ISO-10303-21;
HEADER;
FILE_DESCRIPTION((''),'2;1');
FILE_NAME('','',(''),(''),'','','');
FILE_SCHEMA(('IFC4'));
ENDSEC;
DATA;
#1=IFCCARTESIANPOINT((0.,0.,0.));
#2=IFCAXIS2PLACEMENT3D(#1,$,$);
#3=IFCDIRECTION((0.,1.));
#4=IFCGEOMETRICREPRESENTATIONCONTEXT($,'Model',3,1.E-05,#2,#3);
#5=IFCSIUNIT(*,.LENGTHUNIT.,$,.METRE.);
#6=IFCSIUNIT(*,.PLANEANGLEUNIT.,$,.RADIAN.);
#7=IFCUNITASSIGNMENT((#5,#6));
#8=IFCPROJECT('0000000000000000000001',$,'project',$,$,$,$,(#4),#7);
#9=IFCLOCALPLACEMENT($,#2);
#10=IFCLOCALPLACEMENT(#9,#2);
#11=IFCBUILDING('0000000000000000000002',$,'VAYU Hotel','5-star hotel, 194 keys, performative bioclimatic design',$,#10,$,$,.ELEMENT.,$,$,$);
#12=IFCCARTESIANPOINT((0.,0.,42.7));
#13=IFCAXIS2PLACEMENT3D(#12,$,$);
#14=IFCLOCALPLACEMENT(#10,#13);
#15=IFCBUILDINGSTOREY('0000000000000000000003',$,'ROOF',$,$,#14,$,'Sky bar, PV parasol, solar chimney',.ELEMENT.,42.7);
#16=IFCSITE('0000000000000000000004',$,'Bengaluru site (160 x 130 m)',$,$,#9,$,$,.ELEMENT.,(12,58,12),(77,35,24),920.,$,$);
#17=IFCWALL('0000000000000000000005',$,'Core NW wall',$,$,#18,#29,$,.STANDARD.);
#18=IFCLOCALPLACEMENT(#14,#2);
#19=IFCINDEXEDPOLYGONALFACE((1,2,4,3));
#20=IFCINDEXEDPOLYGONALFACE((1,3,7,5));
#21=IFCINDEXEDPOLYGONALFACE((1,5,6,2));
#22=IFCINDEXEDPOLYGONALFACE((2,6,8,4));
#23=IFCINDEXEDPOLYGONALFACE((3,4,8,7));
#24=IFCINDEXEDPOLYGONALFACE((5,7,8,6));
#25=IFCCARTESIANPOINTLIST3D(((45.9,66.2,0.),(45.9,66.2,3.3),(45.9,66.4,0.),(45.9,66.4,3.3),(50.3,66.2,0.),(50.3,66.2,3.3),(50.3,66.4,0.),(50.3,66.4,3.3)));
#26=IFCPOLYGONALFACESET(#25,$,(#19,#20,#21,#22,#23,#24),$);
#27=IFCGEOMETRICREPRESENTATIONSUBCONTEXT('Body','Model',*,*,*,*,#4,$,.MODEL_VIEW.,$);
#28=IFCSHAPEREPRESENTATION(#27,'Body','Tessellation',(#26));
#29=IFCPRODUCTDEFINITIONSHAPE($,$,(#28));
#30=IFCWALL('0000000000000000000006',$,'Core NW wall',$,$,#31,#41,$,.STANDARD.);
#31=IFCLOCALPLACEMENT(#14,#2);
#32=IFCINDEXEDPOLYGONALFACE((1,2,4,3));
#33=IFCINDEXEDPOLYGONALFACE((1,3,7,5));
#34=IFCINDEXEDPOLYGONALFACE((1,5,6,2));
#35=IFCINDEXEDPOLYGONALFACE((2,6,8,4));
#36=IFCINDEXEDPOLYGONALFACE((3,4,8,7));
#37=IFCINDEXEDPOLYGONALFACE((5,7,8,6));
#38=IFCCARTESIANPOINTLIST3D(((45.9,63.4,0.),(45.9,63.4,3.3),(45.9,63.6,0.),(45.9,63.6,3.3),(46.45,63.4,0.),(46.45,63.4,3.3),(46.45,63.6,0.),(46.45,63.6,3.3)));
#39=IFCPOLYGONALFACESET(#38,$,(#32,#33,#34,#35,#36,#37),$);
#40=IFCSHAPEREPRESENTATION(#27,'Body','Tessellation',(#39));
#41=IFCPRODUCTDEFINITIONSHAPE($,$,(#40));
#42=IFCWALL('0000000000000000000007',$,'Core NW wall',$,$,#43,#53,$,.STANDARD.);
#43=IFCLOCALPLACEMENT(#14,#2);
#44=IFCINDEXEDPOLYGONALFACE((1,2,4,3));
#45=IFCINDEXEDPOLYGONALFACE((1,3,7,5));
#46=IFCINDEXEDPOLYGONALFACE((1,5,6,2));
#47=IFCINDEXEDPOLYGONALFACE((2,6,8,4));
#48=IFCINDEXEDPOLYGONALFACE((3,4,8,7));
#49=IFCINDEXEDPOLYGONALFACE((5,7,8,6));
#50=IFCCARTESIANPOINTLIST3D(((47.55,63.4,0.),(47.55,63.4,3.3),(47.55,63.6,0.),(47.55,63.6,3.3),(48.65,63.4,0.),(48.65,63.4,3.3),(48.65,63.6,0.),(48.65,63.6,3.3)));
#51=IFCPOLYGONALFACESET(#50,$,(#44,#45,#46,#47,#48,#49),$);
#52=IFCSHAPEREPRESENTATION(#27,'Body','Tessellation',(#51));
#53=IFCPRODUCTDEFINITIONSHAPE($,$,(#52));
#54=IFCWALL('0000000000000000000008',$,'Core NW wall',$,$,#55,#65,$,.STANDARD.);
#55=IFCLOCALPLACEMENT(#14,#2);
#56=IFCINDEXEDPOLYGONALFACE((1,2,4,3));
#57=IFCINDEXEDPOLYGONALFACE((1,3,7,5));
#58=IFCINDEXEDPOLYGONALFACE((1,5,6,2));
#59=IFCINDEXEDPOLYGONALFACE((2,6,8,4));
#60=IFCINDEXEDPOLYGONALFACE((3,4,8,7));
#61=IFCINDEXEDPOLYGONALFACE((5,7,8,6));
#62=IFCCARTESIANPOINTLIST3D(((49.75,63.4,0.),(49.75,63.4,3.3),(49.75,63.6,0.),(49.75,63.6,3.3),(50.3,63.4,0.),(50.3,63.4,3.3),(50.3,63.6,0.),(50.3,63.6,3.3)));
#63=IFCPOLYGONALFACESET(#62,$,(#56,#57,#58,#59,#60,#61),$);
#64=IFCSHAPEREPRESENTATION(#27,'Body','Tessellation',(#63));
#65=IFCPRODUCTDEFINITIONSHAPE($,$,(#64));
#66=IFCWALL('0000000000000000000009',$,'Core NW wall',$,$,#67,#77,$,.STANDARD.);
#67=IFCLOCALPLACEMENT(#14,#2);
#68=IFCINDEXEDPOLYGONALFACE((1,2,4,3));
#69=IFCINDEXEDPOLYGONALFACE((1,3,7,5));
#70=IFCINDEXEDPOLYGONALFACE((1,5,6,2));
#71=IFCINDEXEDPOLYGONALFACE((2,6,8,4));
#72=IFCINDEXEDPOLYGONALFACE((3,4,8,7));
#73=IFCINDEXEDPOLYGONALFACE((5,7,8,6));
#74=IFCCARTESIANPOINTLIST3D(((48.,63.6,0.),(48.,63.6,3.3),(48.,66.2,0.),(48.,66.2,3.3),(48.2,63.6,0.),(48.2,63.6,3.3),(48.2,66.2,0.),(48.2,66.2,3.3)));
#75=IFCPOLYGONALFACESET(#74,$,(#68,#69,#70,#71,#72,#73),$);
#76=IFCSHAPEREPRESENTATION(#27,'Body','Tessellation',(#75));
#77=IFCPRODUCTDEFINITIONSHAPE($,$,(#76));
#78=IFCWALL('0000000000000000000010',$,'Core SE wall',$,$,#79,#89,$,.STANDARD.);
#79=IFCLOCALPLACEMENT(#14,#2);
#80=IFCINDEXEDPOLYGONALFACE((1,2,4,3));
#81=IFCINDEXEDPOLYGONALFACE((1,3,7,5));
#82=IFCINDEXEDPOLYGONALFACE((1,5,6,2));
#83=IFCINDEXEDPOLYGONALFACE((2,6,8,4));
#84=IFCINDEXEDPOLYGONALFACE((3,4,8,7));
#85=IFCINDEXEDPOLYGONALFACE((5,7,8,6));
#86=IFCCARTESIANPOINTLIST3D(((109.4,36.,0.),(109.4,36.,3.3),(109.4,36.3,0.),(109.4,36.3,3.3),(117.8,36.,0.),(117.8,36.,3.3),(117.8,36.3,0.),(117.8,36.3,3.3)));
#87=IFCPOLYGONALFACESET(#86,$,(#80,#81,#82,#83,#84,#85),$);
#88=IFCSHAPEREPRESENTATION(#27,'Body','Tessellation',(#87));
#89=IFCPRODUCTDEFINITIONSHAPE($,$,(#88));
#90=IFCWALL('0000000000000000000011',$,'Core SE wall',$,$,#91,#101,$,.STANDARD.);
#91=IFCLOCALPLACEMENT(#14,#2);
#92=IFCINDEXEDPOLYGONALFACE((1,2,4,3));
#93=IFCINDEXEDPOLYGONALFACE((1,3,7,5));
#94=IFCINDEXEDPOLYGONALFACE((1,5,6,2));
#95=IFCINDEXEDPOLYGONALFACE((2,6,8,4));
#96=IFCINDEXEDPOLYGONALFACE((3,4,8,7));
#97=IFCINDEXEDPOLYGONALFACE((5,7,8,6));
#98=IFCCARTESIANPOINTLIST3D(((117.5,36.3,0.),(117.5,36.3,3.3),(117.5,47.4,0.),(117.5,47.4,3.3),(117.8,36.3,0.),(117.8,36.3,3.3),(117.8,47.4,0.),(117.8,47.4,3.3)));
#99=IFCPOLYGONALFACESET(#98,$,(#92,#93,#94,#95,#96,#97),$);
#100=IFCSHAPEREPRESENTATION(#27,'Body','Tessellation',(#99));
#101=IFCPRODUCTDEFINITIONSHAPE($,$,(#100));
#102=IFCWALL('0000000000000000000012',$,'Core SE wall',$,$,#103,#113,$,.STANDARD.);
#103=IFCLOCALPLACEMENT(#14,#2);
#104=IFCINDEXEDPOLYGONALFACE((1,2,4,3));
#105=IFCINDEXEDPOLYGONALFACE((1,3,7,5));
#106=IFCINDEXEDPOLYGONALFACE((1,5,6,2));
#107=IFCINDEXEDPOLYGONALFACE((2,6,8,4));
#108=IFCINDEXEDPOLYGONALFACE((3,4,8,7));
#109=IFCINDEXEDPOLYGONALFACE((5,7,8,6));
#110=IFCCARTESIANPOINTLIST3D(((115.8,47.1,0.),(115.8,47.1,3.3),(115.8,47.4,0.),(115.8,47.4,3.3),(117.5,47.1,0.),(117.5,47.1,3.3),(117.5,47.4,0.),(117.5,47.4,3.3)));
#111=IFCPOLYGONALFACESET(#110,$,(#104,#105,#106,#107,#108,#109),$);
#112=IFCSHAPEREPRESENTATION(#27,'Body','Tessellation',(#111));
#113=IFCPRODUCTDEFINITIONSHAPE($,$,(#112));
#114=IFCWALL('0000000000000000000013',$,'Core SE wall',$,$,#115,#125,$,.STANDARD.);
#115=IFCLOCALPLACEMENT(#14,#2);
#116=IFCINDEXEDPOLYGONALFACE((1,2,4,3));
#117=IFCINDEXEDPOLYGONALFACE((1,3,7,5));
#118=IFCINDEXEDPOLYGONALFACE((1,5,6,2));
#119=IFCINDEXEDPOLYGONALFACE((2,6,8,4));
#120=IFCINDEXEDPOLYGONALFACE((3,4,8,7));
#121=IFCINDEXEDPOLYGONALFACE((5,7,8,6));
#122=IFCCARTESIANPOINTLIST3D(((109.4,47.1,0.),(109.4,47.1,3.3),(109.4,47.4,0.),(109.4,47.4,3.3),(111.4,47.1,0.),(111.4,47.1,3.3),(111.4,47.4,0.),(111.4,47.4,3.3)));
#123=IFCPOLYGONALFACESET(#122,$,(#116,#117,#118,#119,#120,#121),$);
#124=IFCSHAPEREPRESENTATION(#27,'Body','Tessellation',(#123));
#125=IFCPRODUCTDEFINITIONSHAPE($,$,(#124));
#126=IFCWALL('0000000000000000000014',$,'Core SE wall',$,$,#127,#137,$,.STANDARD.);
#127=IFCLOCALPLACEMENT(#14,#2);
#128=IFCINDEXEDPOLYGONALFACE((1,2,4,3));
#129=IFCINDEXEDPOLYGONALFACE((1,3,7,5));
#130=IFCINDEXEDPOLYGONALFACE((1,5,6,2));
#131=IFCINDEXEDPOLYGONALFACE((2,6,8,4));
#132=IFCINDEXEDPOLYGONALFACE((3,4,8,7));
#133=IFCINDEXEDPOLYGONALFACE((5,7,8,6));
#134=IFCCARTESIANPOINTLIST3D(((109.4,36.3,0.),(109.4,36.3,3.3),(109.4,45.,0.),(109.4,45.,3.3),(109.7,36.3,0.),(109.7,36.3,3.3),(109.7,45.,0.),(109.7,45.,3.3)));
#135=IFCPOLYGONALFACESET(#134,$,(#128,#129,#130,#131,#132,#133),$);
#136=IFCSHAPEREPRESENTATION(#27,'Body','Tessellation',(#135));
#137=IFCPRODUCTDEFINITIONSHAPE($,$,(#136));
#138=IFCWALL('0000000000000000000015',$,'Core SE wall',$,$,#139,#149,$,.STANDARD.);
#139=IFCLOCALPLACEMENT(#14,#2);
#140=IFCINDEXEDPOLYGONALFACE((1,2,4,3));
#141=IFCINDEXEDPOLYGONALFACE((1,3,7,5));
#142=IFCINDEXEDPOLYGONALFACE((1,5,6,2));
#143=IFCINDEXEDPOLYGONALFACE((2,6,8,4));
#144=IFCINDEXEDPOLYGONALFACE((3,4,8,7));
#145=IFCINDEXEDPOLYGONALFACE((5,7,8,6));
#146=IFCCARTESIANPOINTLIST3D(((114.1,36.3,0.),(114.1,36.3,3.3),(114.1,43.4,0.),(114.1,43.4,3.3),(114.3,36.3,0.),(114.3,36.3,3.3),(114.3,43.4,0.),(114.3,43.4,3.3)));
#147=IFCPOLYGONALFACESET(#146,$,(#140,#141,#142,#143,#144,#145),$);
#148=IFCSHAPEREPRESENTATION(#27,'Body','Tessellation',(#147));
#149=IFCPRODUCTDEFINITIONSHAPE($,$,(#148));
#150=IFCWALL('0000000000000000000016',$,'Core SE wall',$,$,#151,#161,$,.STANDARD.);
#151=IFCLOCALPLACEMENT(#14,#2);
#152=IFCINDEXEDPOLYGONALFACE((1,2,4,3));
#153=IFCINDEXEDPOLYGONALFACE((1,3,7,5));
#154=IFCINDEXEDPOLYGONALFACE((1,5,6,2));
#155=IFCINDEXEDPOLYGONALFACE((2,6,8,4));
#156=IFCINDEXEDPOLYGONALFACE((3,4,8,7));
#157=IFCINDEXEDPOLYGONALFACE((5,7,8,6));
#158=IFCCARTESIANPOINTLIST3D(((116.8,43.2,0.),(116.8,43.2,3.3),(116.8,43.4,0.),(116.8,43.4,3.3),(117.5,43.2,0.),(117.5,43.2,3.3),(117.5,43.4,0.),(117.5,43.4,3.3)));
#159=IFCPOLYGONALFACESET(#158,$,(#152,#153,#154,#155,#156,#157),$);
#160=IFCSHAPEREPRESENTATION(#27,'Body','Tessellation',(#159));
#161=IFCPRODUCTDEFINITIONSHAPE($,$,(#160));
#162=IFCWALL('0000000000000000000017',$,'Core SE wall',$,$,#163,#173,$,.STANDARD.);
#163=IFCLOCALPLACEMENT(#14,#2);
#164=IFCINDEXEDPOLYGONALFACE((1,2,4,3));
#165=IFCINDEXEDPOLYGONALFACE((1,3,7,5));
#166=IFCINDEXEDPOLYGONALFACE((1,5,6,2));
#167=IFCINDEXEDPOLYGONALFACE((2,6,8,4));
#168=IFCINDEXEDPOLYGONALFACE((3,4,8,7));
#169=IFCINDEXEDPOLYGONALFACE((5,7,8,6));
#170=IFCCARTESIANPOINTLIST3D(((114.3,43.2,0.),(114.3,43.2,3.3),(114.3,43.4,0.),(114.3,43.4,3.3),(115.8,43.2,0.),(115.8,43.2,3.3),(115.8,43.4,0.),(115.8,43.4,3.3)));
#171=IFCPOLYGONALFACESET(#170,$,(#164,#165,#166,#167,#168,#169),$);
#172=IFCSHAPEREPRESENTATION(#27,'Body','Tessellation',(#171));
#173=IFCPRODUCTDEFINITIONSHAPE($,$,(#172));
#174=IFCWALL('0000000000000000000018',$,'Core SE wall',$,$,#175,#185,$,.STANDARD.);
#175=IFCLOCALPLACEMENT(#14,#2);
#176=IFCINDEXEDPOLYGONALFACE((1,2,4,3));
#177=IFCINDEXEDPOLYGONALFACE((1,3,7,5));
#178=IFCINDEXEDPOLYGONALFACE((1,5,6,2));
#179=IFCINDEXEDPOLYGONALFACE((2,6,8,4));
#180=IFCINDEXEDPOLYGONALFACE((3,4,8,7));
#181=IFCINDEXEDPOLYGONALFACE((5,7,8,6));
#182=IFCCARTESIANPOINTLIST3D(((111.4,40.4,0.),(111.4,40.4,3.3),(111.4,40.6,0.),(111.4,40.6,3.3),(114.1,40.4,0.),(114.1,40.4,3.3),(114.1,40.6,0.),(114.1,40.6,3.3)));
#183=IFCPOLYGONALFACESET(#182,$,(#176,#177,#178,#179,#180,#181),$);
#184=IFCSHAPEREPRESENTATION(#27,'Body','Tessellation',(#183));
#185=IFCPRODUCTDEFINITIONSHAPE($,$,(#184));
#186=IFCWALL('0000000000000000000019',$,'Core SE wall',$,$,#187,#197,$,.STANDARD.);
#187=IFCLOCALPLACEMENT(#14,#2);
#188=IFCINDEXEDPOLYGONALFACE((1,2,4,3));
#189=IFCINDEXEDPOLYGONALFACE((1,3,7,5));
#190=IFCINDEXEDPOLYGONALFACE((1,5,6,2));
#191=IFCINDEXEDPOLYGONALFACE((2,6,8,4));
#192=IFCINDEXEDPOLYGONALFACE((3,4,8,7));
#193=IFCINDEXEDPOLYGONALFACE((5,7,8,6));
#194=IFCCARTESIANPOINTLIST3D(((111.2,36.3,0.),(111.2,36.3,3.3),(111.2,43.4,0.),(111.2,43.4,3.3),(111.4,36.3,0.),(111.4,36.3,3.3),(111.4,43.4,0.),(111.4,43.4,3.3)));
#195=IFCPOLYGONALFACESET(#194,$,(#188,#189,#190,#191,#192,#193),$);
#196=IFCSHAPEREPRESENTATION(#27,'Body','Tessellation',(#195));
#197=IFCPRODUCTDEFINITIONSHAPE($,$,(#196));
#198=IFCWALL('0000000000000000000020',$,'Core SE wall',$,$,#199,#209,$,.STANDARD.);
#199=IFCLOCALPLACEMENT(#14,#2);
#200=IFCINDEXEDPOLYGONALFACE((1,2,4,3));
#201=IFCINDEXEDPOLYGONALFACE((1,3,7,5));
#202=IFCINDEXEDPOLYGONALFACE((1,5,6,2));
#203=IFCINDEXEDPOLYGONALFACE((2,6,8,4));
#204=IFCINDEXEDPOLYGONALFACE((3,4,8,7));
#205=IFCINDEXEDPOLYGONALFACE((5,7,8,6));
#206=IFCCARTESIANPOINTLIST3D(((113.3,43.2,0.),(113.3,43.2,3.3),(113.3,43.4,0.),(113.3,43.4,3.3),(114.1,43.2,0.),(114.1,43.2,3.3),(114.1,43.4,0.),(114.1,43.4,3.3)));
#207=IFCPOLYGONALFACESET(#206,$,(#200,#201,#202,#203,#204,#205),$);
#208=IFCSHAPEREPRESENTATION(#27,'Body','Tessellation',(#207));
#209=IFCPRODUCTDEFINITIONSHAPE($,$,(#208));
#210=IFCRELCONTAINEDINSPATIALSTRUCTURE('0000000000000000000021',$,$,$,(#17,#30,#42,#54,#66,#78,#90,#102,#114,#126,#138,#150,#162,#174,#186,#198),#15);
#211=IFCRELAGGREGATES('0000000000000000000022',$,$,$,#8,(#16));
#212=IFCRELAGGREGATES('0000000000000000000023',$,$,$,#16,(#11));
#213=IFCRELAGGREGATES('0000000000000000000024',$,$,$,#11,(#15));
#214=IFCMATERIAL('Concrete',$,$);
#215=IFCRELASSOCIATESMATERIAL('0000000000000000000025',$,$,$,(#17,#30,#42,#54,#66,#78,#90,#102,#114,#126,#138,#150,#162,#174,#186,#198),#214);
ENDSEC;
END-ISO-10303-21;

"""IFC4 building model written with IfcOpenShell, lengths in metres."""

from ifc_helpers import new_model, si_unit, direction, frame, origin, place, context, subcontext, project, spatial, polyline, outline, extrude, material, element, save


model = new_model("IFC4")

# Units and contexts
model_context = context("Model", 3, precision=1e-05, world=origin(), true_north=direction((0.0, 1.0)))
body_context = subcontext(model_context, "Body", "Model", "MODEL_VIEW")
ifc_project = project(units=[si_unit("LENGTHUNIT", "METRE"), si_unit("PLANEANGLEUNIT", "RADIAN")], contexts=[model_context])

# Site, building, storey
site_placement = place(None, origin())
site = spatial("IfcSite", under=ifc_project, at=site_placement, Name="Bengaluru site (160 x 130 m)", CompositionType="ELEMENT", RefLatitude=(12, 58, 12), RefLongitude=(77, 35, 24), RefElevation=920.0)
building_placement = place(site_placement, origin())
building = spatial("IfcBuilding", under=site, at=building_placement, Name="VAYU Hotel", Description="5-star hotel, 194 keys, performative bioclimatic design", CompositionType="ELEMENT")
storey_placement = place(building_placement, frame((0.0, 0.0, 42.7)))
storey = spatial("IfcBuildingStorey", under=building, at=storey_placement, Name="ROOF", LongName="Sky bar, PV parasol, solar chimney", CompositionType="ELEMENT", Elevation=42.7)

# Walls
ifc_material = material(Name="Concrete")
wall_1_placement = place(storey_placement, origin())
element("IfcWall", 1, at=wall_1_placement, inside=storey, material=ifc_material, Name="Core NW wall", PredefinedType="STANDARD", context=body_context, shape_type="SweptSolid", body=[
    extrude(outline(polyline([(45.9, 66.4), (50.3, 66.4), (50.3, 66.2), (45.9, 66.2), (45.9, 66.4)])), origin(), (0.0, 0.0, 1.0), 3.3),
])
wall_2_placement = place(storey_placement, origin())
element("IfcWall", 2, at=wall_2_placement, inside=storey, material=ifc_material, Name="Core NW wall", PredefinedType="STANDARD", context=body_context, shape_type="SweptSolid", body=[
    extrude(outline(polyline([(45.9, 63.6), (46.45, 63.6), (46.45, 63.4), (45.9, 63.4), (45.9, 63.6)])), origin(), (0.0, 0.0, 1.0), 3.3),
])
wall_3_placement = place(storey_placement, origin())
element("IfcWall", 3, at=wall_3_placement, inside=storey, material=ifc_material, Name="Core NW wall", PredefinedType="STANDARD", context=body_context, shape_type="SweptSolid", body=[
    extrude(outline(polyline([(47.55, 63.6), (48.65, 63.6), (48.65, 63.4), (47.55, 63.4), (47.55, 63.6)])), origin(), (0.0, 0.0, 1.0), 3.3),
])
wall_4_placement = place(storey_placement, origin())
element("IfcWall", 4, at=wall_4_placement, inside=storey, material=ifc_material, Name="Core NW wall", PredefinedType="STANDARD", context=body_context, shape_type="SweptSolid", body=[
    extrude(outline(polyline([(49.75, 63.6), (50.3, 63.6), (50.3, 63.4), (49.75, 63.4), (49.75, 63.6)])), origin(), (0.0, 0.0, 1.0), 3.3),
])
wall_5_placement = place(storey_placement, origin())
element("IfcWall", 5, at=wall_5_placement, inside=storey, material=ifc_material, Name="Core NW wall", PredefinedType="STANDARD", context=body_context, shape_type="SweptSolid", body=[
    extrude(outline(polyline([(48.0, 63.6), (48.0, 66.2), (48.2, 66.2), (48.2, 63.6), (48.0, 63.6)])), origin(), (0.0, 0.0, 1.0), 3.3),
])
wall_6_placement = place(storey_placement, origin())
element("IfcWall", 6, at=wall_6_placement, inside=storey, material=ifc_material, Name="Core SE wall", PredefinedType="STANDARD", context=body_context, shape_type="SweptSolid", body=[
    extrude(outline(polyline([(109.4, 36.3), (117.8, 36.3), (117.8, 36.0), (109.4, 36.0), (109.4, 36.3)])), origin(), (0.0, 0.0, 1.0), 3.3),
])
wall_7_placement = place(storey_placement, origin())
element("IfcWall", 7, at=wall_7_placement, inside=storey, material=ifc_material, Name="Core SE wall", PredefinedType="STANDARD", context=body_context, shape_type="SweptSolid", body=[
    extrude(outline(polyline([(117.5, 36.3), (117.5, 47.4), (117.8, 47.4), (117.8, 36.3), (117.5, 36.3)])), origin(), (0.0, 0.0, 1.0), 3.3),
])
wall_8_placement = place(storey_placement, origin())
element("IfcWall", 8, at=wall_8_placement, inside=storey, material=ifc_material, Name="Core SE wall", PredefinedType="STANDARD", context=body_context, shape_type="SweptSolid", body=[
    extrude(outline(polyline([(115.8, 47.4), (117.5, 47.4), (117.5, 47.1), (115.8, 47.1), (115.8, 47.4)])), origin(), (0.0, 0.0, 1.0), 3.3),
])
wall_9_placement = place(storey_placement, origin())
element("IfcWall", 9, at=wall_9_placement, inside=storey, material=ifc_material, Name="Core SE wall", PredefinedType="STANDARD", context=body_context, shape_type="SweptSolid", body=[
    extrude(outline(polyline([(109.4, 47.4), (111.4, 47.4), (111.4, 47.1), (109.4, 47.1), (109.4, 47.4)])), origin(), (0.0, 0.0, 1.0), 3.3),
])
wall_10_placement = place(storey_placement, origin())
element("IfcWall", 10, at=wall_10_placement, inside=storey, material=ifc_material, Name="Core SE wall", PredefinedType="STANDARD", context=body_context, shape_type="SweptSolid", body=[
    extrude(outline(polyline([(109.4, 36.3), (109.4, 45.0), (109.7, 45.0), (109.7, 36.3), (109.4, 36.3)])), origin(), (0.0, 0.0, 1.0), 3.3),
])
wall_11_placement = place(storey_placement, origin())
element("IfcWall", 11, at=wall_11_placement, inside=storey, material=ifc_material, Name="Core SE wall", PredefinedType="STANDARD", context=body_context, shape_type="SweptSolid", body=[
    extrude(outline(polyline([(114.1, 36.3), (114.1, 43.4), (114.3, 43.4), (114.3, 36.3), (114.1, 36.3)])), origin(), (0.0, 0.0, 1.0), 3.3),
])
wall_12_placement = place(storey_placement, origin())
element("IfcWall", 12, at=wall_12_placement, inside=storey, material=ifc_material, Name="Core SE wall", PredefinedType="STANDARD", context=body_context, shape_type="SweptSolid", body=[
    extrude(outline(polyline([(116.8, 43.4), (117.5, 43.4), (117.5, 43.2), (116.8, 43.2), (116.8, 43.4)])), origin(), (0.0, 0.0, 1.0), 3.3),
])
wall_13_placement = place(storey_placement, origin())
element("IfcWall", 13, at=wall_13_placement, inside=storey, material=ifc_material, Name="Core SE wall", PredefinedType="STANDARD", context=body_context, shape_type="SweptSolid", body=[
    extrude(outline(polyline([(114.3, 43.4), (115.8, 43.4), (115.8, 43.2), (114.3, 43.2), (114.3, 43.4)])), origin(), (0.0, 0.0, 1.0), 3.3),
])
wall_14_placement = place(storey_placement, origin())
element("IfcWall", 14, at=wall_14_placement, inside=storey, material=ifc_material, Name="Core SE wall", PredefinedType="STANDARD", context=body_context, shape_type="SweptSolid", body=[
    extrude(outline(polyline([(111.4, 40.6), (114.1, 40.6), (114.1, 40.4), (111.4, 40.4), (111.4, 40.6)])), origin(), (0.0, 0.0, 1.0), 3.3),
])
wall_15_placement = place(storey_placement, origin())
element("IfcWall", 15, at=wall_15_placement, inside=storey, material=ifc_material, Name="Core SE wall", PredefinedType="STANDARD", context=body_context, shape_type="SweptSolid", body=[
    extrude(outline(polyline([(111.2, 36.3), (111.2, 43.4), (111.4, 43.4), (111.4, 36.3), (111.2, 36.3)])), origin(), (0.0, 0.0, 1.0), 3.3),
])
wall_16_placement = place(storey_placement, origin())
element("IfcWall", 16, at=wall_16_placement, inside=storey, material=ifc_material, Name="Core SE wall", PredefinedType="STANDARD", context=body_context, shape_type="SweptSolid", body=[
    extrude(outline(polyline([(113.3, 43.4), (114.1, 43.4), (114.1, 43.2), (113.3, 43.2), (113.3, 43.4)])), origin(), (0.0, 0.0, 1.0), 3.3),
])

save(model, "model.ifc")
